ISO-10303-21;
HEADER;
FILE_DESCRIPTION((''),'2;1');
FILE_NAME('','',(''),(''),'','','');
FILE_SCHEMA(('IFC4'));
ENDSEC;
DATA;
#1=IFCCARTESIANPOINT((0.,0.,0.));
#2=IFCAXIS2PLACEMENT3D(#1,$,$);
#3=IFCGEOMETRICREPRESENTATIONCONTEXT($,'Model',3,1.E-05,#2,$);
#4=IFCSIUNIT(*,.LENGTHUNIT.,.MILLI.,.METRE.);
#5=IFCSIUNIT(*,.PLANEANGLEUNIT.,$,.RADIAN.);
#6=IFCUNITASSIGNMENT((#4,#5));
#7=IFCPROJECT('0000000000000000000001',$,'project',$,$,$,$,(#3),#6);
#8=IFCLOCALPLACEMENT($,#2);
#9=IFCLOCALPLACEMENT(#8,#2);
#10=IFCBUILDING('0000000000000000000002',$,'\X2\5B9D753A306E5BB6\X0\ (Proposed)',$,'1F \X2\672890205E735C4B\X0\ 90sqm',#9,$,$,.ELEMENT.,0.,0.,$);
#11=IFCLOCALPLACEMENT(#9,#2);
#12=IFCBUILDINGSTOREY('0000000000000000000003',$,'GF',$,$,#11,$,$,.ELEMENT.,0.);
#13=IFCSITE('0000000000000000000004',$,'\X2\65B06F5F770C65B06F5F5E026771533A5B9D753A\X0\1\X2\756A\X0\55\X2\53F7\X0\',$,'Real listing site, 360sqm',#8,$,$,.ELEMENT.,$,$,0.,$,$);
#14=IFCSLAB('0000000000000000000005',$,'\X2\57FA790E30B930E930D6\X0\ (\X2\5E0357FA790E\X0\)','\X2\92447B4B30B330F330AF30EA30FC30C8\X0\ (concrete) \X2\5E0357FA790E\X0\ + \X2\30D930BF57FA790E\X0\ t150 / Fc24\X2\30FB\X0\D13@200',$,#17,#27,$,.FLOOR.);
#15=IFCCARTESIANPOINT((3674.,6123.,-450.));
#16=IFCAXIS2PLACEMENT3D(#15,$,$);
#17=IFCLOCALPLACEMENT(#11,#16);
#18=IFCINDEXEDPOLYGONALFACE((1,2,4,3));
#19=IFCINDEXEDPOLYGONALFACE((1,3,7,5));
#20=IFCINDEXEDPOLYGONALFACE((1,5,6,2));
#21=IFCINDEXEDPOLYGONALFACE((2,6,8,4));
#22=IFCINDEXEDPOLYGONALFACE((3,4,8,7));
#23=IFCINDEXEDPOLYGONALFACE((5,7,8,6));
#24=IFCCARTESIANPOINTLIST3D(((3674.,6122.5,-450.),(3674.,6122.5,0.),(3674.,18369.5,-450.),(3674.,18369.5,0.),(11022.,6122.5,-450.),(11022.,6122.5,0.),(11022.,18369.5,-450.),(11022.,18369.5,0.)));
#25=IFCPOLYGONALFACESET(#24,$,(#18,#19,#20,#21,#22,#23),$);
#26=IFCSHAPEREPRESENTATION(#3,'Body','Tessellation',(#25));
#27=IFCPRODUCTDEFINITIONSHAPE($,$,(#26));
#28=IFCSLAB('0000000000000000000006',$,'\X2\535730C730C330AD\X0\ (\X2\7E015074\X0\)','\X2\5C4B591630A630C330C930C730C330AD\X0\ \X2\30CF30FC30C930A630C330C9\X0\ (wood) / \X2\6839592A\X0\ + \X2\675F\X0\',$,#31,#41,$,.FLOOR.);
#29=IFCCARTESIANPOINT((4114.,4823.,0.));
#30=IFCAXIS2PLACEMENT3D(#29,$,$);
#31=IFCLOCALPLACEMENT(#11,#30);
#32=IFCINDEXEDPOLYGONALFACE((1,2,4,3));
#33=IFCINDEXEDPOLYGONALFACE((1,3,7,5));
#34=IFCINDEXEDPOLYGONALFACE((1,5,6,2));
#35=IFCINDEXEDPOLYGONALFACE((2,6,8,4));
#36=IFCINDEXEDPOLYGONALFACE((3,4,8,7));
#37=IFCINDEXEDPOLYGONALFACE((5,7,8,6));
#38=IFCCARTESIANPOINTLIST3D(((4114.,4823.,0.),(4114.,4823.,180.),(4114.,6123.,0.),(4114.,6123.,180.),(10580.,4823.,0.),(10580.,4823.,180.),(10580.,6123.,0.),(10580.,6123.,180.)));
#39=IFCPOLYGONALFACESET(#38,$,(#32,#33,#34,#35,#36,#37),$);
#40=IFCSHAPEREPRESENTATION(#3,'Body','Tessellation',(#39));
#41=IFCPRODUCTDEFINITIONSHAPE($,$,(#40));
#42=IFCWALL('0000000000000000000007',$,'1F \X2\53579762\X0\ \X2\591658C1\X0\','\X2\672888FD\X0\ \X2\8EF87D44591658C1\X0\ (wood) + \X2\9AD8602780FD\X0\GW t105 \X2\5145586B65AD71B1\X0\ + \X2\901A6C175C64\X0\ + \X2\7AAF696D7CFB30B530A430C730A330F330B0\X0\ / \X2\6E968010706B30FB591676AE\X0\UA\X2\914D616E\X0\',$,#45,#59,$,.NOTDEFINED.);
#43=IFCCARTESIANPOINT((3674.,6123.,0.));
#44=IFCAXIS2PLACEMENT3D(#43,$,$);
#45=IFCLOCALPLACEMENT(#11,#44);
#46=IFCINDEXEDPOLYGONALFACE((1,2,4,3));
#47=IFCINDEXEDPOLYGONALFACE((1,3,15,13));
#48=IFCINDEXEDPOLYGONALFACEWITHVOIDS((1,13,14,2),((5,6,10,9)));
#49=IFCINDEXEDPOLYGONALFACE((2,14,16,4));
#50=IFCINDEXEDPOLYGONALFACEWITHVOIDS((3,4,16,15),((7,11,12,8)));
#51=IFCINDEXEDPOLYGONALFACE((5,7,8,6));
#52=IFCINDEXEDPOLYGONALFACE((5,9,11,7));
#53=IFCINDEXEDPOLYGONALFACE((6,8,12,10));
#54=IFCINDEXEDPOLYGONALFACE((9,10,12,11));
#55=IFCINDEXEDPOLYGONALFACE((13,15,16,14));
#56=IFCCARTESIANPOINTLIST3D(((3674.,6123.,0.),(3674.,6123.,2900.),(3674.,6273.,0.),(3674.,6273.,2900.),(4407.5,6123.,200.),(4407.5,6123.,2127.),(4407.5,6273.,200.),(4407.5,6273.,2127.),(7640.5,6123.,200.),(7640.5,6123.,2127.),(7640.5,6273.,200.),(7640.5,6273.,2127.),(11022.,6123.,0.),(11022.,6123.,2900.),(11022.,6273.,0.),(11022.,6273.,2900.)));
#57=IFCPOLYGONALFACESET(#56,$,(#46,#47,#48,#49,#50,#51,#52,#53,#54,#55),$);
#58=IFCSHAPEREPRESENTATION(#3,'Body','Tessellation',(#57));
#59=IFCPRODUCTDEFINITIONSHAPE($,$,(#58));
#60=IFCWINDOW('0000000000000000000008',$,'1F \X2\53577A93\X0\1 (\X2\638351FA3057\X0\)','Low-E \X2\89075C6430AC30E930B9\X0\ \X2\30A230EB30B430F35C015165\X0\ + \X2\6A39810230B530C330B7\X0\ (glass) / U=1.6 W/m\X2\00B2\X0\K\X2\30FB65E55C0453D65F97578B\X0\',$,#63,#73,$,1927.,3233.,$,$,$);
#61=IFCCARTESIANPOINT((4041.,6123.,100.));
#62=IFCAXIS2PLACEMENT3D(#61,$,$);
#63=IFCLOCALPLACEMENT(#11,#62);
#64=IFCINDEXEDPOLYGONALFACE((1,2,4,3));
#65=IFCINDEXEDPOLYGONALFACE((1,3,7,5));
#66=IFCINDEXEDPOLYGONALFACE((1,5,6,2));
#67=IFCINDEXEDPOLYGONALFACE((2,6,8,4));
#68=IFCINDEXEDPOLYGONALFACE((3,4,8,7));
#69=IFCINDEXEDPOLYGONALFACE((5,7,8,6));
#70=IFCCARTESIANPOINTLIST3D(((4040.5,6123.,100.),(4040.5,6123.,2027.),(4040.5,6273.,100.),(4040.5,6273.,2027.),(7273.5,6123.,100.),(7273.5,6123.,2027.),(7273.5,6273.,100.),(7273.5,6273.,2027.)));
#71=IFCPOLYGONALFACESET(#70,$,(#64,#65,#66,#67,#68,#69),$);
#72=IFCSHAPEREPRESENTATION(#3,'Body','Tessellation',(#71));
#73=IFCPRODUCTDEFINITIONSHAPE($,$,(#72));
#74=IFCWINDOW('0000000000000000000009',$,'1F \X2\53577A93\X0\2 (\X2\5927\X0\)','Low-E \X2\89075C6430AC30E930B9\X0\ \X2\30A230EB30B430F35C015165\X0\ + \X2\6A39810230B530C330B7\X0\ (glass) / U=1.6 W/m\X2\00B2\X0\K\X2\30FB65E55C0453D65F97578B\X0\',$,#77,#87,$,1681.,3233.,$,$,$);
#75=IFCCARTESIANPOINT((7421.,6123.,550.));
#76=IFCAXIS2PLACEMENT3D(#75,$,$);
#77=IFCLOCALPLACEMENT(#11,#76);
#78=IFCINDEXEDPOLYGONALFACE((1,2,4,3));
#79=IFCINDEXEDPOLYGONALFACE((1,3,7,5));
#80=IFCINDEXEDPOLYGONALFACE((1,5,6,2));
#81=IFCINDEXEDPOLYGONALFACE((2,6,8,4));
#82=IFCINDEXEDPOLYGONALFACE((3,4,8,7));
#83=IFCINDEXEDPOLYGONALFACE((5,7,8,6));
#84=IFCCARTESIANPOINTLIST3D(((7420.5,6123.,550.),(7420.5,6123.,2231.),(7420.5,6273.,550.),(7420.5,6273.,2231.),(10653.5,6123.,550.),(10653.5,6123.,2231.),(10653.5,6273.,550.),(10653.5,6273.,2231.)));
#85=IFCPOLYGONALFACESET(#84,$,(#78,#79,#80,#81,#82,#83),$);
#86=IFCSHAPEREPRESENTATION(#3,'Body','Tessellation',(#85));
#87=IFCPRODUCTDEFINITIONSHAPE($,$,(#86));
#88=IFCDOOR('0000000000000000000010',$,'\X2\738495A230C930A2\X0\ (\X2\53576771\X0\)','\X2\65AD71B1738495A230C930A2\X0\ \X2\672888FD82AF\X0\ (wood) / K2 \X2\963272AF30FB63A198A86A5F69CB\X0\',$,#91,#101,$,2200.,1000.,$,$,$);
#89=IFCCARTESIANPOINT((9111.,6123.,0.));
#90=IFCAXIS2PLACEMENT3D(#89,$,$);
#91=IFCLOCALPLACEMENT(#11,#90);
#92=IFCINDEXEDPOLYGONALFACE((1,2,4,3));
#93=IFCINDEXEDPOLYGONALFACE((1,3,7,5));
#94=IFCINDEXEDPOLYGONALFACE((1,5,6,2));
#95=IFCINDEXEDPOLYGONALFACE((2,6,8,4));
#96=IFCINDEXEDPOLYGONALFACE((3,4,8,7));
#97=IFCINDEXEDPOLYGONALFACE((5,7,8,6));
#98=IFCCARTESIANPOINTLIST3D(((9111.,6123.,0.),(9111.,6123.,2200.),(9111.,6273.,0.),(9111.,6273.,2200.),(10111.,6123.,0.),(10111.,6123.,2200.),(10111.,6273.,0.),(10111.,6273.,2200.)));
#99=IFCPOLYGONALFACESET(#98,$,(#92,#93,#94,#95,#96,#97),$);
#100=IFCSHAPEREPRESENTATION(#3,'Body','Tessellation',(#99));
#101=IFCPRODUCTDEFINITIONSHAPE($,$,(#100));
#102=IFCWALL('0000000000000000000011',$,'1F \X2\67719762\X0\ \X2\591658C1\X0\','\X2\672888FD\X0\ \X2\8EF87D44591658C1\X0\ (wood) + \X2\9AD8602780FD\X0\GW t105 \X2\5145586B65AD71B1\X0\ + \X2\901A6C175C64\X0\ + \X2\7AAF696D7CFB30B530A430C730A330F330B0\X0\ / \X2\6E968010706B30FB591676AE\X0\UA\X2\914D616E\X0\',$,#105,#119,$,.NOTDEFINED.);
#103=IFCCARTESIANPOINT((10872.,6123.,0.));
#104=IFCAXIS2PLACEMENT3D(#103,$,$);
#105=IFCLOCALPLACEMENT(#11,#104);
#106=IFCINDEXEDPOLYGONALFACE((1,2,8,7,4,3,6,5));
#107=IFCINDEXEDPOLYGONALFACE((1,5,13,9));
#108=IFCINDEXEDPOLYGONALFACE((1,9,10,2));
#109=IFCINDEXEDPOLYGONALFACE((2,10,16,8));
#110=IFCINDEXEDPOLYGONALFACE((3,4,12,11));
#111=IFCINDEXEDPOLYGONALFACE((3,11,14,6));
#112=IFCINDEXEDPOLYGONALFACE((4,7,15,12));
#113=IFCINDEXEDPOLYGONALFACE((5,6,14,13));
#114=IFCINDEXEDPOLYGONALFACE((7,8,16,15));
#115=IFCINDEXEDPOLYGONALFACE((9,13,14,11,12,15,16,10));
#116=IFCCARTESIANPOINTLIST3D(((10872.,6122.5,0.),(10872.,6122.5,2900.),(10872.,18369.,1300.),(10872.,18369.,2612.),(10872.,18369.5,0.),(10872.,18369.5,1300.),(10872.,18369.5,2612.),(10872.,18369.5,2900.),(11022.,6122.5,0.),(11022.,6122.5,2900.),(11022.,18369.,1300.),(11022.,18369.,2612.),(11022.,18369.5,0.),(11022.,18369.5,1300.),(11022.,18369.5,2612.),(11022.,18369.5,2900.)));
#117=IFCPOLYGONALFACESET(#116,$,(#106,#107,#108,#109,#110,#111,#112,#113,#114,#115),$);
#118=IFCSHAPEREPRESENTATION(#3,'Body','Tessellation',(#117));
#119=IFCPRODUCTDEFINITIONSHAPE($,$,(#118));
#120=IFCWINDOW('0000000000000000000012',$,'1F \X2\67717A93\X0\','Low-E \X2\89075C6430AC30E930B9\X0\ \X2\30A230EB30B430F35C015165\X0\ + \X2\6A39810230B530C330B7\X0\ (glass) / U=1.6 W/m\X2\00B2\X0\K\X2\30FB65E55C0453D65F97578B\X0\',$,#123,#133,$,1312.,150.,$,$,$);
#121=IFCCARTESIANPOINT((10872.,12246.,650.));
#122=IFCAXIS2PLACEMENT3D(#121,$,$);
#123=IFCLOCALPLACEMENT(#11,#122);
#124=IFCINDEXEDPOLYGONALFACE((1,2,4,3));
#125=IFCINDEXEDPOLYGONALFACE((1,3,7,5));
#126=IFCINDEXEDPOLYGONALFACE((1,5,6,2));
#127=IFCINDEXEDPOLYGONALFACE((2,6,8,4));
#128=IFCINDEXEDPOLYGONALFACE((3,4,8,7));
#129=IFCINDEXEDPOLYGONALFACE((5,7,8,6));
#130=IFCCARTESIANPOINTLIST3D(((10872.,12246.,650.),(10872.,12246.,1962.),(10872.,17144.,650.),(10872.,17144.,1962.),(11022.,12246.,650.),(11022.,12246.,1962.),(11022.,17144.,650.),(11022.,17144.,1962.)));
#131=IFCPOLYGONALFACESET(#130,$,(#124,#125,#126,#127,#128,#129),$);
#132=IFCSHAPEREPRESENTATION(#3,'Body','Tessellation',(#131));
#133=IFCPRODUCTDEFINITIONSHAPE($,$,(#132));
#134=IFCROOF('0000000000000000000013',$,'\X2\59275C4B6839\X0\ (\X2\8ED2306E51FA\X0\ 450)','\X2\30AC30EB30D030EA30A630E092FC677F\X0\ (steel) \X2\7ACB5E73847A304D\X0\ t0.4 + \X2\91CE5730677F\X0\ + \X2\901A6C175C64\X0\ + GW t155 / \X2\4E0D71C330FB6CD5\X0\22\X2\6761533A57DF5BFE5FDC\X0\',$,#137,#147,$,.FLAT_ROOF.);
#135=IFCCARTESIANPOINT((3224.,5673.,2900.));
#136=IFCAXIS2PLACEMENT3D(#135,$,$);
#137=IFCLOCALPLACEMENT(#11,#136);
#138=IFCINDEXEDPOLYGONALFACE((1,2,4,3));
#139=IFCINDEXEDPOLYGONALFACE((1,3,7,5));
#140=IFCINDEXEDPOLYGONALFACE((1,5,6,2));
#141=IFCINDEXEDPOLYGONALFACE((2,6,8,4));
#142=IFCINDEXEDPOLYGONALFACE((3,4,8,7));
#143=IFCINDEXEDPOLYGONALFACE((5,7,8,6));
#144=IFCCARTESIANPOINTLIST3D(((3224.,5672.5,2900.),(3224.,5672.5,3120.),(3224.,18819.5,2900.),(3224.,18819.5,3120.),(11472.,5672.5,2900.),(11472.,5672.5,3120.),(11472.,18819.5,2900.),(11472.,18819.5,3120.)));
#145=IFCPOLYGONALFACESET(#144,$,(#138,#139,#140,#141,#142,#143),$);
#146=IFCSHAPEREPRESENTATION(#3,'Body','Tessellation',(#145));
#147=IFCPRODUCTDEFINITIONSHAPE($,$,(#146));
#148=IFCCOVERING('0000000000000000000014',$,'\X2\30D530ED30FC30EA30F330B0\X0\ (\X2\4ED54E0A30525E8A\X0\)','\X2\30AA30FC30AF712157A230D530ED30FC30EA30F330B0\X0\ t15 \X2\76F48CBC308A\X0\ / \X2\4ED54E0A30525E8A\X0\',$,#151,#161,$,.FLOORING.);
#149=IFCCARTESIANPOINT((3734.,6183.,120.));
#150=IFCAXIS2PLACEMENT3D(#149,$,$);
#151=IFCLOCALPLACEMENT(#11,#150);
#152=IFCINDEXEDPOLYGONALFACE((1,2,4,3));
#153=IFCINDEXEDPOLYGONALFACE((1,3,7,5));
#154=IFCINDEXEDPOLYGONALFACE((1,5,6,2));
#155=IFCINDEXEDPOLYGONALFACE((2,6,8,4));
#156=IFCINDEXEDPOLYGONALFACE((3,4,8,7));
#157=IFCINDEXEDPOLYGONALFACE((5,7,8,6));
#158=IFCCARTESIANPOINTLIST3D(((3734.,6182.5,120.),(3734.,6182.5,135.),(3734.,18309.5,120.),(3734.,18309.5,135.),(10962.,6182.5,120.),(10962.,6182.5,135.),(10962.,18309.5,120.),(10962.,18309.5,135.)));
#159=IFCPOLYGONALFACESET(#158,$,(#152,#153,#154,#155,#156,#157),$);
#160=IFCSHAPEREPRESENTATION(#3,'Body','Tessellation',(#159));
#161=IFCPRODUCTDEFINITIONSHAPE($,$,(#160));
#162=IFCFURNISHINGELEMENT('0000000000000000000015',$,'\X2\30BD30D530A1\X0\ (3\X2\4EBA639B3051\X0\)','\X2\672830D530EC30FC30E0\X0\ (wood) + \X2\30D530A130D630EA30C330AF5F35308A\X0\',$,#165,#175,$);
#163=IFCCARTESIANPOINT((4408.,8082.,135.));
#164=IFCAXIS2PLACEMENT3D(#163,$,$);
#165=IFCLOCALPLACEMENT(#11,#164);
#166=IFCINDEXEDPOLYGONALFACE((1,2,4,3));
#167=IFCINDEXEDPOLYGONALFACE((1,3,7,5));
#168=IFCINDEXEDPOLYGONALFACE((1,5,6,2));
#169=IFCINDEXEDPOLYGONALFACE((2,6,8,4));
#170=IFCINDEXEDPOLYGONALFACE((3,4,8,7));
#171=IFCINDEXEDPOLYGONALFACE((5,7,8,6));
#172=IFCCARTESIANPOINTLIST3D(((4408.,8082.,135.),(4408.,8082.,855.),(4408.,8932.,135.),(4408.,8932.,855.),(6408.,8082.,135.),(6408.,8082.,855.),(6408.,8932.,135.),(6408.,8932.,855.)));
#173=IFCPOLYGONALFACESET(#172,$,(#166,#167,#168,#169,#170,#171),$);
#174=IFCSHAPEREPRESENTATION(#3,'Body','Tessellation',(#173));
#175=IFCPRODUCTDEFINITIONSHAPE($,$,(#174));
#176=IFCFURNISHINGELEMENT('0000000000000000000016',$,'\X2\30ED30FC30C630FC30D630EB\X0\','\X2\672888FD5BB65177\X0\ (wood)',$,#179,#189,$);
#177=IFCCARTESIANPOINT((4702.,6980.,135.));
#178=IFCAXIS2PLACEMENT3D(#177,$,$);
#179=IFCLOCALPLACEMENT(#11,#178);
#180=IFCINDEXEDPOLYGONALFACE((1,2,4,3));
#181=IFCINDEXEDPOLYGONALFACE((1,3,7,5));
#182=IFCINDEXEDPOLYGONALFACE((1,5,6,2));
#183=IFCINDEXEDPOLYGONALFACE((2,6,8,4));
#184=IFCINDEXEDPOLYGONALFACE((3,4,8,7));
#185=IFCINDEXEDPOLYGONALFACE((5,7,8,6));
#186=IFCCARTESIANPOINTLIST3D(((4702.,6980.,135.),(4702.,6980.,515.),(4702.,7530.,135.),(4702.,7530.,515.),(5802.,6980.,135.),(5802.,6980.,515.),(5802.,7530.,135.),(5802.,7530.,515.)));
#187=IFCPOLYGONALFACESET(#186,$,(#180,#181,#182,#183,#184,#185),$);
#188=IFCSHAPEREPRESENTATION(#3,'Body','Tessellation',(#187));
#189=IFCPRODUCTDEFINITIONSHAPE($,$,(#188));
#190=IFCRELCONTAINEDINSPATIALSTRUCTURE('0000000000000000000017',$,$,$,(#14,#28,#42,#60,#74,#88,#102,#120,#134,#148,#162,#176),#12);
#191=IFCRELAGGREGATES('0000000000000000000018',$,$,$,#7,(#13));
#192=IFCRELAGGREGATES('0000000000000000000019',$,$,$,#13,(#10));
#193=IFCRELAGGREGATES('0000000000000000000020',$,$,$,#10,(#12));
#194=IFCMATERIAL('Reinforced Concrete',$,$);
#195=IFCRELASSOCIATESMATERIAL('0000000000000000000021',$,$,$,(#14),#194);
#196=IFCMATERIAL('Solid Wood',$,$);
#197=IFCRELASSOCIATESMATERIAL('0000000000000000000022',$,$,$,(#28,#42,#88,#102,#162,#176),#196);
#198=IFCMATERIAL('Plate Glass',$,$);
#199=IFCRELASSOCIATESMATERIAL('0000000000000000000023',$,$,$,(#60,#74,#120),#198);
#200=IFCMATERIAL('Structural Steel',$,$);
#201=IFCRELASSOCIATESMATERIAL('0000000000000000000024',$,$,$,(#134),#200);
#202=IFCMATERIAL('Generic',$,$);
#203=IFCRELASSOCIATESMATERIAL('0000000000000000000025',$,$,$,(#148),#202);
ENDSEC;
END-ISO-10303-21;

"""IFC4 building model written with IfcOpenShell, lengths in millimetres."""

from ifc_helpers import new_model, si_unit, frame, frame_2d, origin, place, context, project, spatial, rectangle, extrude, material, element, fill, save


model = new_model("IFC4")

# Units and contexts
model_context = context("Model", 3, precision=1e-05, world=origin())
ifc_project = project(units=[si_unit("LENGTHUNIT", "METRE", prefix="MILLI"), si_unit("PLANEANGLEUNIT", "RADIAN")], contexts=[model_context])

# Site, building, storey
site_placement = place(None, origin())
site = spatial("IfcSite", under=ifc_project, at=site_placement, Name="新潟県新潟市東区宝町1番55号", ObjectType="Real listing site, 360sqm", CompositionType="ELEMENT", RefElevation=0.0)
building_placement = place(site_placement, origin())
building = spatial("IfcBuilding", under=site, at=building_placement, Name="宝町の家 (Proposed)", ObjectType="1F 木造平屋 90sqm", CompositionType="ELEMENT", ElevationOfRefHeight=0.0, ElevationOfTerrain=0.0)
storey_placement = place(building_placement, origin())
storey = spatial("IfcBuildingStorey", under=building, at=storey_placement, Name="GF", CompositionType="ELEMENT", Elevation=0.0)

# Slabs
ifc_material_1 = material(Name="Reinforced Concrete")
slab_1_placement = place(storey_placement, frame((3674.0, 6123.0, -450.0)))
element("IfcSlab", 1, at=slab_1_placement, inside=storey, material=ifc_material_1, Name="基礎スラブ (布基礎)", Description="鉄筋コンクリート (concrete) 布基礎 + ベタ基礎 t150 / Fc24・D13@200", PredefinedType="FLOOR", context=model_context, shape_type="SweptSolid", body=[
    extrude(rectangle(XDim=7348.0, YDim=12247.0, at=frame_2d((3674.0, 6123.0))), frame((3674.0, 6123.0, -450.0)), (0.0, 0.0, 1.0), 450.0),
])
ifc_material_2 = material(Name="Solid Wood")
slab_2_placement = place(storey_placement, frame((4114.0, 4823.0, 0.0)))
element("IfcSlab", 2, at=slab_2_placement, inside=storey, material=ifc_material_2, Name="南デッキ (縁側)", Description="屋外ウッドデッキ ハードウッド (wood) / 根太 + 束", PredefinedType="FLOOR", context=model_context, shape_type="SweptSolid", body=[
    extrude(rectangle(XDim=6466.0, YDim=1300.0, at=frame_2d((3233.0, 650.0))), frame((4114.0, 4823.0, 0.0)), (0.0, 0.0, 1.0), 180.0),
])

# Wall, openings, windows, door
wall_1_placement = place(storey_placement, frame((3674.0, 6123.0, 0.0)))
wall_1 = element("IfcWall", 3, at=wall_1_placement, inside=storey, material=ifc_material_2, Name="1F 南面 外壁", Description="木製 軸組外壁 (wood) + 高性能GW t105 充填断熱 + 通気層 + 窯業系サイディング / 準耐火・外皮UA配慮", PredefinedType="NOTDEFINED", context=model_context, shape_type="SweptSolid", body=[
    extrude(rectangle(XDim=7348.0, YDim=150.0, at=frame_2d((3674.0, 75.0))), frame((3674.0, 6123.0, 0.0)), (0.0, 0.0, 1.0), 2900.0),
])
opening_1_placement = place(storey_placement, frame((4041.0, 6123.0, 100.0)))
opening_1 = element("IfcOpeningElement", 4, at=opening_1_placement, cuts=wall_1, PredefinedType="NOTDEFINED", context=model_context, shape_type="SweptSolid", body=[
    extrude(rectangle(XDim=3233.0, YDim=150.0, at=frame_2d((1616.0, 75.0))), frame((4041.0, 6123.0, 100.0)), (0.0, 0.0, 1.0), 1927.0),
])
opening_2_placement = place(storey_placement, frame((7421.0, 6123.0, 550.0)))
opening_2 = element("IfcOpeningElement", 5, at=opening_2_placement, cuts=wall_1, PredefinedType="NOTDEFINED", context=model_context, shape_type="SweptSolid", body=[
    extrude(rectangle(XDim=3233.0, YDim=150.0, at=frame_2d((1616.0, 75.0))), frame((7421.0, 6123.0, 550.0)), (0.0, 0.0, 1.0), 1681.0),
])
opening_3_placement = place(storey_placement, frame((9111.0, 6123.0, 0.0)))
opening_3 = element("IfcOpeningElement", 6, at=opening_3_placement, cuts=wall_1, PredefinedType="NOTDEFINED", context=model_context, shape_type="SweptSolid", body=[
    extrude(rectangle(XDim=1000.0, YDim=150.0, at=frame_2d((500.0, 75.0))), frame((9111.0, 6123.0, 0.0)), (0.0, 0.0, 1.0), 2200.0),
])
ifc_material_3 = material(Name="Plate Glass")
window_1_placement = place(storey_placement, frame((4041.0, 6123.0, 100.0)))
window_1 = element("IfcWindow", 7, at=window_1_placement, inside=storey, material=ifc_material_3, Name="1F 南窓1 (掃出し)", Description="Low-E 複層ガラス アルゴン封入 + 樹脂サッシ (glass) / U=1.6 W/m²K・日射取得型", OverallHeight=1927.0, OverallWidth=3233.0, context=model_context, shape_type="SweptSolid", body=[
    extrude(rectangle(XDim=3233.0, YDim=150.0, at=frame_2d((1616.0, 75.0))), frame((4041.0, 6123.0, 100.0)), (0.0, 0.0, 1.0), 1927.0),
])
fill(opening_1, window_1)
window_2_placement = place(storey_placement, frame((7421.0, 6123.0, 550.0)))
window_2 = element("IfcWindow", 8, at=window_2_placement, inside=storey, material=ifc_material_3, Name="1F 南窓2 (大)", Description="Low-E 複層ガラス アルゴン封入 + 樹脂サッシ (glass) / U=1.6 W/m²K・日射取得型", OverallHeight=1681.0, OverallWidth=3233.0, context=model_context, shape_type="SweptSolid", body=[
    extrude(rectangle(XDim=3233.0, YDim=150.0, at=frame_2d((1616.0, 75.0))), frame((7421.0, 6123.0, 550.0)), (0.0, 0.0, 1.0), 1681.0),
])
fill(opening_2, window_2)
door_placement = place(storey_placement, frame((9111.0, 6123.0, 0.0)))
door = element("IfcDoor", 9, at=door_placement, inside=storey, material=ifc_material_2, Name="玄関ドア (南東)", Description="断熱玄関ドア 木製芯 (wood) / K2 防犯・採風機構", OverallHeight=2200.0, OverallWidth=1000.0, context=model_context, shape_type="SweptSolid", body=[
    extrude(rectangle(XDim=1000.0, YDim=150.0, at=frame_2d((500.0, 75.0))), frame((9111.0, 6123.0, 0.0)), (0.0, 0.0, 1.0), 2200.0),
])
fill(opening_3, door)

# Wall, opening, window
wall_2_placement = place(storey_placement, frame((10872.0, 6123.0, 0.0)))
wall_2 = element("IfcWall", 10, at=wall_2_placement, inside=storey, material=ifc_material_2, Name="1F 東面 外壁", Description="木製 軸組外壁 (wood) + 高性能GW t105 充填断熱 + 通気層 + 窯業系サイディング / 準耐火・外皮UA配慮", PredefinedType="NOTDEFINED", context=model_context, shape_type="SweptSolid", body=[
    extrude(rectangle(XDim=150.0, YDim=12247.0, at=frame_2d((75.0, 6123.0))), frame((10872.0, 6123.0, 0.0)), (0.0, 0.0, 1.0), 2900.0),
])
opening_4_placement = place(storey_placement, frame((10872.0, 12246.0, 650.0)))
opening_4 = element("IfcOpeningElement", 11, at=opening_4_placement, cuts=wall_2, PredefinedType="NOTDEFINED", context=model_context, shape_type="SweptSolid", body=[
    extrude(rectangle(XDim=150.0, YDim=4898.0, at=frame_2d((75.0, 2449.0))), frame((10872.0, 12246.0, 650.0)), (0.0, 0.0, 1.0), 1312.0),
])
window_3_placement = place(storey_placement, frame((10872.0, 12246.0, 650.0)))
window_3 = element("IfcWindow", 12, at=window_3_placement, inside=storey, material=ifc_material_3, Name="1F 東窓", Description="Low-E 複層ガラス アルゴン封入 + 樹脂サッシ (glass) / U=1.6 W/m²K・日射取得型", OverallHeight=1312.0, OverallWidth=150.0, context=model_context, shape_type="SweptSolid", body=[
    extrude(rectangle(XDim=150.0, YDim=4898.0, at=frame_2d((75.0, 2449.0))), frame((10872.0, 12246.0, 650.0)), (0.0, 0.0, 1.0), 1312.0),
])
fill(opening_4, window_3)

# Roof
ifc_material_4 = material(Name="Structural Steel")
roof_placement = place(storey_placement, frame((3224.0, 5673.0, 2900.0)))
element("IfcRoof", 13, at=roof_placement, inside=storey, material=ifc_material_4, Name="大屋根 (軒の出 450)", Description="ガルバリウム鋼板 (steel) 立平葺き t0.4 + 野地板 + 通気層 + GW t155 / 不燃・法22条区域対応", PredefinedType="FLAT_ROOF", context=model_context, shape_type="SweptSolid", body=[
    extrude(rectangle(XDim=8248.0, YDim=13147.0, at=frame_2d((4124.0, 6573.0))), frame((3224.0, 5673.0, 2900.0)), (0.0, 0.0, 1.0), 220.0),
])

# Covering
ifc_material_5 = material(Name="Generic")
covering_placement = place(storey_placement, frame((3734.0, 6183.0, 120.0)))
element("IfcCovering", 14, at=covering_placement, inside=storey, material=ifc_material_5, Name="フローリング (仕上げ床)", Description="オーク無垢フローリング t15 直貼り / 仕上げ床", PredefinedType="FLOORING", context=model_context, shape_type="SweptSolid", body=[
    extrude(rectangle(XDim=7228.0, YDim=12127.0, at=frame_2d((3614.0, 6063.0))), frame((3734.0, 6183.0, 120.0)), (0.0, 0.0, 1.0), 15.0),
])

# Furnishing elements
furnishing_1_placement = place(storey_placement, frame((4408.0, 8082.0, 135.0)))
element("IfcFurnishingElement", 15, at=furnishing_1_placement, inside=storey, material=ifc_material_2, Name="ソファ (3人掛け)", Description="木フレーム (wood) + ファブリック張り", context=model_context, shape_type="SweptSolid", body=[
    extrude(rectangle(XDim=2000.0, YDim=850.0, at=frame_2d((1000.0, 425.0))), frame((4408.0, 8082.0, 135.0)), (0.0, 0.0, 1.0), 720.0),
])
furnishing_2_placement = place(storey_placement, frame((4702.0, 6980.0, 135.0)))
element("IfcFurnishingElement", 16, at=furnishing_2_placement, inside=storey, material=ifc_material_2, Name="ローテーブル", Description="木製家具 (wood)", context=model_context, shape_type="SweptSolid", body=[
    extrude(rectangle(XDim=1100.0, YDim=550.0, at=frame_2d((550.0, 275.0))), frame((4702.0, 6980.0, 135.0)), (0.0, 0.0, 1.0), 380.0),
])

save(model, "model.ifc")
